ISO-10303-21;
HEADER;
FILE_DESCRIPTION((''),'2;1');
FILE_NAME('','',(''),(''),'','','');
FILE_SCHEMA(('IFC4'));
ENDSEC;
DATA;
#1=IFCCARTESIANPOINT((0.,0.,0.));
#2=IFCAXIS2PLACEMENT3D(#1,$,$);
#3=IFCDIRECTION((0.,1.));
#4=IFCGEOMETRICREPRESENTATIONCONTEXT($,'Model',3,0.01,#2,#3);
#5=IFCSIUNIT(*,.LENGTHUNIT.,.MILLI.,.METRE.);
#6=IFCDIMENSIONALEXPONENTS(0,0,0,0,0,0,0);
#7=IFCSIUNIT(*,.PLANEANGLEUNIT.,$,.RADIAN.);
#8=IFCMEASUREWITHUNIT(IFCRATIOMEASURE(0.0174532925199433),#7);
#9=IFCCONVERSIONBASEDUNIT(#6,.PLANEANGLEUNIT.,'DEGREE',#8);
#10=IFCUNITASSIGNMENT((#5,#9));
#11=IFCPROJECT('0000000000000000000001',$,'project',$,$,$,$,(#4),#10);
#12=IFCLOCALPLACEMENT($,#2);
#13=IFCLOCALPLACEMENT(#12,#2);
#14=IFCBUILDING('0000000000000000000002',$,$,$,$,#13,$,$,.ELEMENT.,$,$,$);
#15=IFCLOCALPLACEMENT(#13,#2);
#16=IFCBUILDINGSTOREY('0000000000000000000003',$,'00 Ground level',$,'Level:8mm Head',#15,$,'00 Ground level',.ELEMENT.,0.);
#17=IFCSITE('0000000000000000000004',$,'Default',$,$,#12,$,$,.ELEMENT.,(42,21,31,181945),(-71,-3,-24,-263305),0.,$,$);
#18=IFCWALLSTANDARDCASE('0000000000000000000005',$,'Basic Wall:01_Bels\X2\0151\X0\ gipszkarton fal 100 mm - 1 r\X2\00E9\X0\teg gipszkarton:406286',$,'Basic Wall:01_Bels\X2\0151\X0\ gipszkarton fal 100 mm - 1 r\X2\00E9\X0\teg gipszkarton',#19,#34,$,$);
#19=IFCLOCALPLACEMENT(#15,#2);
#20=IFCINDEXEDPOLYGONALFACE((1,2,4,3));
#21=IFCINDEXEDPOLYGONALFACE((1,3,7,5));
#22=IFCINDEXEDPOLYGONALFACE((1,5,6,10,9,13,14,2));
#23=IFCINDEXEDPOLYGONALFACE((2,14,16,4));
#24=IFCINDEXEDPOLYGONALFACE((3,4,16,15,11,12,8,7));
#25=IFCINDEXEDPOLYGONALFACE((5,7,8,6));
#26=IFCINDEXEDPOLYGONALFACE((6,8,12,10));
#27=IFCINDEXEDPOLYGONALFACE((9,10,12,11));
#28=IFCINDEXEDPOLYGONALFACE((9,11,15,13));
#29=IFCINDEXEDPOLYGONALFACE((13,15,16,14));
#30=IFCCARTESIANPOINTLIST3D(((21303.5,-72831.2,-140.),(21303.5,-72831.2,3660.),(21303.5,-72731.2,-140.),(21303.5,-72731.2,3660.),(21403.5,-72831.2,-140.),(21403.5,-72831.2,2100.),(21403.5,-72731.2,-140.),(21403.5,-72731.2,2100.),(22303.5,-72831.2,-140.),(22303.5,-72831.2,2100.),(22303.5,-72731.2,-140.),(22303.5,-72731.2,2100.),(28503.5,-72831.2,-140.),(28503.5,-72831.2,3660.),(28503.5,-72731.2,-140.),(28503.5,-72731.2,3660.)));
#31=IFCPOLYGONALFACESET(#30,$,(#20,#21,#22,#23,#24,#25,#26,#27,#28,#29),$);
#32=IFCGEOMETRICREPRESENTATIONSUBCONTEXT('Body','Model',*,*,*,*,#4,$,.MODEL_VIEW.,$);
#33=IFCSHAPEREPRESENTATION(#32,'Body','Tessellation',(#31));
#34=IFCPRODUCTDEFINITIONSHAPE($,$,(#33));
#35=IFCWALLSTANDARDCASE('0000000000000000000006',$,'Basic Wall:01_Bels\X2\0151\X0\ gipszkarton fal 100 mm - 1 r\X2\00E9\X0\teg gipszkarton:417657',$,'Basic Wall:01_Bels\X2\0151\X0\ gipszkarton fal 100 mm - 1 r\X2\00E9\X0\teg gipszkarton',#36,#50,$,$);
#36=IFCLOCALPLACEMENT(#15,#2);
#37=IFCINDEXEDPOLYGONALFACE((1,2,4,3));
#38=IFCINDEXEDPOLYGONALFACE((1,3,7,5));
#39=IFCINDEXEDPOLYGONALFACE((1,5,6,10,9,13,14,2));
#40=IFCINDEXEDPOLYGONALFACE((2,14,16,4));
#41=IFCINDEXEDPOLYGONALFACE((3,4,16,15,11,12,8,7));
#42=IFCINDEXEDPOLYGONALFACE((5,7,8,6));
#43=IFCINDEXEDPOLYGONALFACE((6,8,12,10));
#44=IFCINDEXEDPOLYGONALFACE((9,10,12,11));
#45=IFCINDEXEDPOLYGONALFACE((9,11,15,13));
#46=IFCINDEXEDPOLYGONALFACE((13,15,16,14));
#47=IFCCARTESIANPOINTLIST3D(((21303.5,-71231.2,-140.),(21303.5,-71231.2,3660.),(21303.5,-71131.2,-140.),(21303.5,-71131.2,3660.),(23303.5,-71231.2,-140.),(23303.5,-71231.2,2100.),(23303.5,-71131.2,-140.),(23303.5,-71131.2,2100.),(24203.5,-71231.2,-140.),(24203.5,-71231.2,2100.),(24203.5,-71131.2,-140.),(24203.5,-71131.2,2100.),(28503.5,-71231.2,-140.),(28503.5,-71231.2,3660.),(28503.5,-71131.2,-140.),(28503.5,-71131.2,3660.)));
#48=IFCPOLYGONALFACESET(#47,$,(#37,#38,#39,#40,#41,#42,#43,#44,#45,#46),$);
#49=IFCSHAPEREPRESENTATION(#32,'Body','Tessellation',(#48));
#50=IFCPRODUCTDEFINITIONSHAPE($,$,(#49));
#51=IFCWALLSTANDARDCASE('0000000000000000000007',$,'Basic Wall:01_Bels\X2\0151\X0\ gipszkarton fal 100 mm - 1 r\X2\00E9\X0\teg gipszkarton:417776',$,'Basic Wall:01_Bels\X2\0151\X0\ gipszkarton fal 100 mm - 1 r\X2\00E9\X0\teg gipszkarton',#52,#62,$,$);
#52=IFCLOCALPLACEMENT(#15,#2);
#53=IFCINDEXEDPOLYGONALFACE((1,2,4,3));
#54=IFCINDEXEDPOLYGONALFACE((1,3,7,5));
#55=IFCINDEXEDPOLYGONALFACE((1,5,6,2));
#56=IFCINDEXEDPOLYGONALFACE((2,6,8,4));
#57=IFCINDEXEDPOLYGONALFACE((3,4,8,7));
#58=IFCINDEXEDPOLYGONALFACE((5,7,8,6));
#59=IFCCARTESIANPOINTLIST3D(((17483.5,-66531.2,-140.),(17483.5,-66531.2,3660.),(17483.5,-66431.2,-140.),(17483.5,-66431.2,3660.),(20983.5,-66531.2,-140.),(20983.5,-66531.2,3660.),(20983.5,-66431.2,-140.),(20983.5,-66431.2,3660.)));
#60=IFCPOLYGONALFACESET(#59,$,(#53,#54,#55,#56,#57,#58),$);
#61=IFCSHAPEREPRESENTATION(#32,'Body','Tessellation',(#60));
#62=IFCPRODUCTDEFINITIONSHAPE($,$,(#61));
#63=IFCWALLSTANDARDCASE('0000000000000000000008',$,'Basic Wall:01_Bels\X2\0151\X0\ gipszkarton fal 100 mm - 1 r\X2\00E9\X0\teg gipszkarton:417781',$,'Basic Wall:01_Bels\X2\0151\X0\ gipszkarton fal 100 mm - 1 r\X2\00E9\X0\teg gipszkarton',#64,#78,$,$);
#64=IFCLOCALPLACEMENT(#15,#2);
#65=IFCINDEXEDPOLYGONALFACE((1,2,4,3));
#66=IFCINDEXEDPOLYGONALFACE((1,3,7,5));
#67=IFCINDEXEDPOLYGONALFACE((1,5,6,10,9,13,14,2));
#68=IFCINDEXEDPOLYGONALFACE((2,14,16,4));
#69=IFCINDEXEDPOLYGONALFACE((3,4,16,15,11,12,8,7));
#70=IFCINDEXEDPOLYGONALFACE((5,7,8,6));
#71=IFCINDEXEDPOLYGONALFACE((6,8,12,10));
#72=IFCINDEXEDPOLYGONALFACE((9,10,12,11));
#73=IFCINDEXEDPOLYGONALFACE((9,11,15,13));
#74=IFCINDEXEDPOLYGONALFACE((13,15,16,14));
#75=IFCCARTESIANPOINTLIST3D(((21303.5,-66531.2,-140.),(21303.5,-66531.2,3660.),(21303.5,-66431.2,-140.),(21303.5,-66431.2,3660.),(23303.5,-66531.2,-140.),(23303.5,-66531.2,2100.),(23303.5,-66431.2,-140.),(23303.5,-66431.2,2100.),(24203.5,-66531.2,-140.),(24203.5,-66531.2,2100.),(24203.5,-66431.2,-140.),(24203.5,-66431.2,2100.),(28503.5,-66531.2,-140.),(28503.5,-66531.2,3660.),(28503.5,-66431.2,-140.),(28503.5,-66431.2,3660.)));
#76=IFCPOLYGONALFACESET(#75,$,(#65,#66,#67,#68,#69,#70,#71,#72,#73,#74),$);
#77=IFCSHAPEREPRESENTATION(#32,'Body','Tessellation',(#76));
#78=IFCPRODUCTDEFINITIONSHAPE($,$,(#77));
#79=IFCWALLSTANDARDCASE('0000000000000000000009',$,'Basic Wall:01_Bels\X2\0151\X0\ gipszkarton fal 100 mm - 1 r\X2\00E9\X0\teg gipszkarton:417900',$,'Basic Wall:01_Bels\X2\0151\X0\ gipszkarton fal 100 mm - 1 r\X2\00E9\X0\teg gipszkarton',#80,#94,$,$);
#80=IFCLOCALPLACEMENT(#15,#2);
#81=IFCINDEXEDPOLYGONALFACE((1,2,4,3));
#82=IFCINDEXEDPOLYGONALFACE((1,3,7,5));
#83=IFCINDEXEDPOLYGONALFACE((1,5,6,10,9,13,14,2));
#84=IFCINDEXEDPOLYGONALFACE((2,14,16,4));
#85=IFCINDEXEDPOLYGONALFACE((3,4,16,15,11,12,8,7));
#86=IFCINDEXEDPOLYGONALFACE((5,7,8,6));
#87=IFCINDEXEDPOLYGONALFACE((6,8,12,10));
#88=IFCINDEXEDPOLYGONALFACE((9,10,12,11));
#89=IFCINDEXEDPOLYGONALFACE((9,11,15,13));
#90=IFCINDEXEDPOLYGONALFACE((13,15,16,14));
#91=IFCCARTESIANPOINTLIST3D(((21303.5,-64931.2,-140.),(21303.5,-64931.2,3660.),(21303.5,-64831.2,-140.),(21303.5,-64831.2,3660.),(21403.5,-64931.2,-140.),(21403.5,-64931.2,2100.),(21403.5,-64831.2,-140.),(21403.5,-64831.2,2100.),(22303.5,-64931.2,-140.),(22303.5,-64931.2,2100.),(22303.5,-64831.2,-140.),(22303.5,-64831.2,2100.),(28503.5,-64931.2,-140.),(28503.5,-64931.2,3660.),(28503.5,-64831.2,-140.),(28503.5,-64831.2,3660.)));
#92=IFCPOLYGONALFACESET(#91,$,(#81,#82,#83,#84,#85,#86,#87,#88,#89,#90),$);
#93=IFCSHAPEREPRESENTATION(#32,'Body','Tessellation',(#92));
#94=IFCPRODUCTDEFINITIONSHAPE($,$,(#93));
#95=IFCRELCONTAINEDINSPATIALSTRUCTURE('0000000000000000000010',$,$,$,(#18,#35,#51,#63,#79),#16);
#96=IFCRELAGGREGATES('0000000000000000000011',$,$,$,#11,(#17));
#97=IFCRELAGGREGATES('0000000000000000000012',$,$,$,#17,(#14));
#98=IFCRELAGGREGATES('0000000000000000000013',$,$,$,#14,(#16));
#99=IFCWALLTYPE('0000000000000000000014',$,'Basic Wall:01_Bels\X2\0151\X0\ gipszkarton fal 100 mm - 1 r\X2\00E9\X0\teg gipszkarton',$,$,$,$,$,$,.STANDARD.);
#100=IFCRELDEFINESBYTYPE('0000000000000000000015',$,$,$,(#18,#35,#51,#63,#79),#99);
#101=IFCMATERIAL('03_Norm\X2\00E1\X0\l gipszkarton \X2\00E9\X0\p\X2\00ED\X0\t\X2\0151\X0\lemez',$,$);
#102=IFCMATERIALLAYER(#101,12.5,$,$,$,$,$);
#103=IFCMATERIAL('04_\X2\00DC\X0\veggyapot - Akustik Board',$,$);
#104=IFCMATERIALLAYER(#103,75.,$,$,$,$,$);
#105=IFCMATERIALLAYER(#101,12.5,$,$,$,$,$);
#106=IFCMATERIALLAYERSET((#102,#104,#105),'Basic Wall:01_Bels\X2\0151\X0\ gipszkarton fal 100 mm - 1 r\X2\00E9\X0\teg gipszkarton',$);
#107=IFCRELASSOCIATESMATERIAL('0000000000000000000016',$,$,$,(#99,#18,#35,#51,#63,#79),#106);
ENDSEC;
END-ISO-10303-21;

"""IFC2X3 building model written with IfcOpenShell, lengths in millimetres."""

from ifc_helpers import new_model, entity, si_unit, converted_unit, direction, frame, frame_2d, origin, place, context, subcontext, project, spatial, rectangle, extrude, material, layer, layer_set, layer_usage, type_object, element, save


model = new_model("IFC2X3")

# Units and contexts
model_context = context("Model", 3, precision=0.01, world=origin(), true_north=direction((0.0, 1.0)))
body_context = subcontext(model_context, "Body", "Model", "MODEL_VIEW")
ifc_project = project(units=[si_unit("LENGTHUNIT", "METRE", prefix="MILLI"), converted_unit("PLANEANGLEUNIT", "DEGREE", entity("IfcRatioMeasure", 0.0174532925199433), si_unit("PLANEANGLEUNIT", "RADIAN"), dimensions=[0, 0, 0, 0, 0, 0, 0])], contexts=[model_context])

# Site, building, storey
site_placement = place(None, origin())
site = spatial("IfcSite", under=ifc_project, at=site_placement, Name="Default", CompositionType="ELEMENT", RefLatitude=(42, 21, 31, 181945), RefLongitude=(-71, -3, -24, -263305), RefElevation=0.0)
building_placement = place(site_placement, origin())
building = spatial("IfcBuilding", under=site, at=building_placement, CompositionType="ELEMENT")
storey_placement = place(building_placement, origin())
storey = spatial("IfcBuildingStorey", under=building, at=storey_placement, Name="00 Ground level", ObjectType="Level:8mm Head", LongName="00 Ground level", CompositionType="ELEMENT", Elevation=0.0)

# Shared definitions
ifc_material_1 = material(Name="03_Normál gipszkarton építőlemez")
ifc_layer_1 = layer(ifc_material_1, 12.5)
ifc_material_2 = material(Name="04_Üveggyapot - Akustik Board")
ifc_layer_2 = layer(ifc_material_2, 75.0)
ifc_layer_3 = layer(ifc_material_1, 12.5)
ifc_layer_set_1 = layer_set([ifc_layer_1, ifc_layer_2, ifc_layer_3], Name="Basic Wall:01_Belső gipszkarton fal 100 mm - 1 réteg gipszkarton")
wall_type_1 = type_object("IfcWallType", Name="Basic Wall:01_Belső gipszkarton fal 100 mm - 1 réteg gipszkarton", PredefinedType="STANDARD", material=ifc_layer_set_1)

# Walls, openings
ifc_layer_usage_1 = layer_usage(ifc_layer_set_1, "AXIS2", "NEGATIVE", 50.0)
wall_1_placement = place(storey_placement, frame((21303.5, -72781.2, -140.0)))
wall_1 = element("IfcWallStandardCase", 1, at=wall_1_placement, inside=storey, type_object=wall_type_1, material=ifc_layer_usage_1, Name="Basic Wall:01_Belső gipszkarton fal 100 mm - 1 réteg gipszkarton:406286", ObjectType="Basic Wall:01_Belső gipszkarton fal 100 mm - 1 réteg gipszkarton", context=body_context, shape_type="SweptSolid", body=[
    extrude(rectangle(XDim=7200.0, YDim=100.0, at=frame_2d((3600.0, 0.0), x_axis=(-1.0, 0.0))), origin(), (0.0, 0.0, 1.0), 3800.0),
])
opening_1_placement = place(wall_1_placement, frame((100.0, -1474.0, 0.0)))
element("IfcOpeningElement", 2, at=opening_1_placement, cuts=wall_1, ObjectType="Opening", context=body_context, shape_type="SweptSolid", body=[
    extrude(rectangle(XDim=2240.0, YDim=900.0, at=frame_2d((0.0, 0.0), x_axis=(0.0, 1.0))), frame((450.0, 0.0, 1120.0), z_axis=(0.0, 1.0, 0.0), x_axis=(-1.0, 0.0, 0.0)), (0.0, 0.0, 1.0), 3048.0),
])
ifc_layer_usage_2 = layer_usage(ifc_layer_set_1, "AXIS2", "NEGATIVE", 50.0)
wall_2_placement = place(storey_placement, frame((21303.5, -71181.2, -140.0)))
wall_2 = element("IfcWallStandardCase", 3, at=wall_2_placement, inside=storey, type_object=wall_type_1, material=ifc_layer_usage_2, Name="Basic Wall:01_Belső gipszkarton fal 100 mm - 1 réteg gipszkarton:417657", ObjectType="Basic Wall:01_Belső gipszkarton fal 100 mm - 1 réteg gipszkarton", context=body_context, shape_type="SweptSolid", body=[
    extrude(rectangle(XDim=7200.0, YDim=100.0, at=frame_2d((3600.0, 0.0), x_axis=(-1.0, 0.0))), origin(), (0.0, 0.0, 1.0), 3800.0),
])
opening_2_placement = place(wall_2_placement, frame((2000.0, -1574.0, 0.0)))
element("IfcOpeningElement", 4, at=opening_2_placement, cuts=wall_2, ObjectType="Opening", context=body_context, shape_type="SweptSolid", body=[
    extrude(rectangle(XDim=2240.0, YDim=900.0, at=frame_2d((0.0, 0.0), x_axis=(1.0, 0.0))), frame((450.0, 0.0, 1120.0), z_axis=(0.0, 1.0, 0.0), x_axis=(0.0, 0.0, 1.0)), (0.0, 0.0, 1.0), 3048.0),
])

# Wall
ifc_layer_usage_3 = layer_usage(ifc_layer_set_1, "AXIS2", "POSITIVE", -50.0)
wall_3_placement = place(storey_placement, frame((17483.5, -66481.2, -140.0)))
element("IfcWallStandardCase", 5, at=wall_3_placement, inside=storey, type_object=wall_type_1, material=ifc_layer_usage_3, Name="Basic Wall:01_Belső gipszkarton fal 100 mm - 1 réteg gipszkarton:417776", ObjectType="Basic Wall:01_Belső gipszkarton fal 100 mm - 1 réteg gipszkarton", context=body_context, shape_type="SweptSolid", body=[
    extrude(rectangle(XDim=3500.0, YDim=100.0, at=frame_2d((1750.0, 0.0), x_axis=(-1.0, 0.0))), origin(), (0.0, 0.0, 1.0), 3800.0),
])

# Walls, openings
ifc_layer_usage_4 = layer_usage(ifc_layer_set_1, "AXIS2", "POSITIVE", -50.0)
wall_4_placement = place(storey_placement, frame((21303.5, -66481.2, -140.0)))
wall_4 = element("IfcWallStandardCase", 6, at=wall_4_placement, inside=storey, type_object=wall_type_1, material=ifc_layer_usage_4, Name="Basic Wall:01_Belső gipszkarton fal 100 mm - 1 réteg gipszkarton:417781", ObjectType="Basic Wall:01_Belső gipszkarton fal 100 mm - 1 réteg gipszkarton", context=body_context, shape_type="SweptSolid", body=[
    extrude(rectangle(XDim=7200.0, YDim=100.0, at=frame_2d((3600.0, 0.0), x_axis=(-1.0, 0.0))), origin(), (0.0, 0.0, 1.0), 3800.0),
])
opening_3_placement = place(wall_4_placement, frame((2000.0, -1474.0, 0.0)))
element("IfcOpeningElement", 7, at=opening_3_placement, cuts=wall_4, ObjectType="Opening", context=body_context, shape_type="SweptSolid", body=[
    extrude(rectangle(XDim=2240.0, YDim=900.0, at=frame_2d((0.0, 0.0), x_axis=(1.0, 0.0))), frame((450.0, 0.0, 1120.0), z_axis=(0.0, 1.0, 0.0), x_axis=(0.0, 0.0, 1.0)), (0.0, 0.0, 1.0), 3048.0),
])
ifc_layer_usage_5 = layer_usage(ifc_layer_set_1, "AXIS2", "POSITIVE", -50.0)
wall_5_placement = place(storey_placement, frame((21303.5, -64881.2, -140.0)))
wall_5 = element("IfcWallStandardCase", 8, at=wall_5_placement, inside=storey, type_object=wall_type_1, material=ifc_layer_usage_5, Name="Basic Wall:01_Belső gipszkarton fal 100 mm - 1 réteg gipszkarton:417900", ObjectType="Basic Wall:01_Belső gipszkarton fal 100 mm - 1 réteg gipszkarton", context=body_context, shape_type="SweptSolid", body=[
    extrude(rectangle(XDim=7200.0, YDim=100.0, at=frame_2d((3600.0, 0.0), x_axis=(-1.0, 0.0))), origin(), (0.0, 0.0, 1.0), 3800.0),
])
opening_4_placement = place(wall_5_placement, frame((100.0, -1574.0, 0.0)))
element("IfcOpeningElement", 9, at=opening_4_placement, cuts=wall_5, ObjectType="Opening", context=body_context, shape_type="SweptSolid", body=[
    extrude(rectangle(XDim=2240.0, YDim=900.0, at=frame_2d((0.0, 0.0), x_axis=(0.0, 1.0))), frame((450.0, 0.0, 1120.0), z_axis=(0.0, 1.0, 0.0), x_axis=(-1.0, 0.0, 0.0)), (0.0, 0.0, 1.0), 3048.0),
])

save(model, "model.ifc")
